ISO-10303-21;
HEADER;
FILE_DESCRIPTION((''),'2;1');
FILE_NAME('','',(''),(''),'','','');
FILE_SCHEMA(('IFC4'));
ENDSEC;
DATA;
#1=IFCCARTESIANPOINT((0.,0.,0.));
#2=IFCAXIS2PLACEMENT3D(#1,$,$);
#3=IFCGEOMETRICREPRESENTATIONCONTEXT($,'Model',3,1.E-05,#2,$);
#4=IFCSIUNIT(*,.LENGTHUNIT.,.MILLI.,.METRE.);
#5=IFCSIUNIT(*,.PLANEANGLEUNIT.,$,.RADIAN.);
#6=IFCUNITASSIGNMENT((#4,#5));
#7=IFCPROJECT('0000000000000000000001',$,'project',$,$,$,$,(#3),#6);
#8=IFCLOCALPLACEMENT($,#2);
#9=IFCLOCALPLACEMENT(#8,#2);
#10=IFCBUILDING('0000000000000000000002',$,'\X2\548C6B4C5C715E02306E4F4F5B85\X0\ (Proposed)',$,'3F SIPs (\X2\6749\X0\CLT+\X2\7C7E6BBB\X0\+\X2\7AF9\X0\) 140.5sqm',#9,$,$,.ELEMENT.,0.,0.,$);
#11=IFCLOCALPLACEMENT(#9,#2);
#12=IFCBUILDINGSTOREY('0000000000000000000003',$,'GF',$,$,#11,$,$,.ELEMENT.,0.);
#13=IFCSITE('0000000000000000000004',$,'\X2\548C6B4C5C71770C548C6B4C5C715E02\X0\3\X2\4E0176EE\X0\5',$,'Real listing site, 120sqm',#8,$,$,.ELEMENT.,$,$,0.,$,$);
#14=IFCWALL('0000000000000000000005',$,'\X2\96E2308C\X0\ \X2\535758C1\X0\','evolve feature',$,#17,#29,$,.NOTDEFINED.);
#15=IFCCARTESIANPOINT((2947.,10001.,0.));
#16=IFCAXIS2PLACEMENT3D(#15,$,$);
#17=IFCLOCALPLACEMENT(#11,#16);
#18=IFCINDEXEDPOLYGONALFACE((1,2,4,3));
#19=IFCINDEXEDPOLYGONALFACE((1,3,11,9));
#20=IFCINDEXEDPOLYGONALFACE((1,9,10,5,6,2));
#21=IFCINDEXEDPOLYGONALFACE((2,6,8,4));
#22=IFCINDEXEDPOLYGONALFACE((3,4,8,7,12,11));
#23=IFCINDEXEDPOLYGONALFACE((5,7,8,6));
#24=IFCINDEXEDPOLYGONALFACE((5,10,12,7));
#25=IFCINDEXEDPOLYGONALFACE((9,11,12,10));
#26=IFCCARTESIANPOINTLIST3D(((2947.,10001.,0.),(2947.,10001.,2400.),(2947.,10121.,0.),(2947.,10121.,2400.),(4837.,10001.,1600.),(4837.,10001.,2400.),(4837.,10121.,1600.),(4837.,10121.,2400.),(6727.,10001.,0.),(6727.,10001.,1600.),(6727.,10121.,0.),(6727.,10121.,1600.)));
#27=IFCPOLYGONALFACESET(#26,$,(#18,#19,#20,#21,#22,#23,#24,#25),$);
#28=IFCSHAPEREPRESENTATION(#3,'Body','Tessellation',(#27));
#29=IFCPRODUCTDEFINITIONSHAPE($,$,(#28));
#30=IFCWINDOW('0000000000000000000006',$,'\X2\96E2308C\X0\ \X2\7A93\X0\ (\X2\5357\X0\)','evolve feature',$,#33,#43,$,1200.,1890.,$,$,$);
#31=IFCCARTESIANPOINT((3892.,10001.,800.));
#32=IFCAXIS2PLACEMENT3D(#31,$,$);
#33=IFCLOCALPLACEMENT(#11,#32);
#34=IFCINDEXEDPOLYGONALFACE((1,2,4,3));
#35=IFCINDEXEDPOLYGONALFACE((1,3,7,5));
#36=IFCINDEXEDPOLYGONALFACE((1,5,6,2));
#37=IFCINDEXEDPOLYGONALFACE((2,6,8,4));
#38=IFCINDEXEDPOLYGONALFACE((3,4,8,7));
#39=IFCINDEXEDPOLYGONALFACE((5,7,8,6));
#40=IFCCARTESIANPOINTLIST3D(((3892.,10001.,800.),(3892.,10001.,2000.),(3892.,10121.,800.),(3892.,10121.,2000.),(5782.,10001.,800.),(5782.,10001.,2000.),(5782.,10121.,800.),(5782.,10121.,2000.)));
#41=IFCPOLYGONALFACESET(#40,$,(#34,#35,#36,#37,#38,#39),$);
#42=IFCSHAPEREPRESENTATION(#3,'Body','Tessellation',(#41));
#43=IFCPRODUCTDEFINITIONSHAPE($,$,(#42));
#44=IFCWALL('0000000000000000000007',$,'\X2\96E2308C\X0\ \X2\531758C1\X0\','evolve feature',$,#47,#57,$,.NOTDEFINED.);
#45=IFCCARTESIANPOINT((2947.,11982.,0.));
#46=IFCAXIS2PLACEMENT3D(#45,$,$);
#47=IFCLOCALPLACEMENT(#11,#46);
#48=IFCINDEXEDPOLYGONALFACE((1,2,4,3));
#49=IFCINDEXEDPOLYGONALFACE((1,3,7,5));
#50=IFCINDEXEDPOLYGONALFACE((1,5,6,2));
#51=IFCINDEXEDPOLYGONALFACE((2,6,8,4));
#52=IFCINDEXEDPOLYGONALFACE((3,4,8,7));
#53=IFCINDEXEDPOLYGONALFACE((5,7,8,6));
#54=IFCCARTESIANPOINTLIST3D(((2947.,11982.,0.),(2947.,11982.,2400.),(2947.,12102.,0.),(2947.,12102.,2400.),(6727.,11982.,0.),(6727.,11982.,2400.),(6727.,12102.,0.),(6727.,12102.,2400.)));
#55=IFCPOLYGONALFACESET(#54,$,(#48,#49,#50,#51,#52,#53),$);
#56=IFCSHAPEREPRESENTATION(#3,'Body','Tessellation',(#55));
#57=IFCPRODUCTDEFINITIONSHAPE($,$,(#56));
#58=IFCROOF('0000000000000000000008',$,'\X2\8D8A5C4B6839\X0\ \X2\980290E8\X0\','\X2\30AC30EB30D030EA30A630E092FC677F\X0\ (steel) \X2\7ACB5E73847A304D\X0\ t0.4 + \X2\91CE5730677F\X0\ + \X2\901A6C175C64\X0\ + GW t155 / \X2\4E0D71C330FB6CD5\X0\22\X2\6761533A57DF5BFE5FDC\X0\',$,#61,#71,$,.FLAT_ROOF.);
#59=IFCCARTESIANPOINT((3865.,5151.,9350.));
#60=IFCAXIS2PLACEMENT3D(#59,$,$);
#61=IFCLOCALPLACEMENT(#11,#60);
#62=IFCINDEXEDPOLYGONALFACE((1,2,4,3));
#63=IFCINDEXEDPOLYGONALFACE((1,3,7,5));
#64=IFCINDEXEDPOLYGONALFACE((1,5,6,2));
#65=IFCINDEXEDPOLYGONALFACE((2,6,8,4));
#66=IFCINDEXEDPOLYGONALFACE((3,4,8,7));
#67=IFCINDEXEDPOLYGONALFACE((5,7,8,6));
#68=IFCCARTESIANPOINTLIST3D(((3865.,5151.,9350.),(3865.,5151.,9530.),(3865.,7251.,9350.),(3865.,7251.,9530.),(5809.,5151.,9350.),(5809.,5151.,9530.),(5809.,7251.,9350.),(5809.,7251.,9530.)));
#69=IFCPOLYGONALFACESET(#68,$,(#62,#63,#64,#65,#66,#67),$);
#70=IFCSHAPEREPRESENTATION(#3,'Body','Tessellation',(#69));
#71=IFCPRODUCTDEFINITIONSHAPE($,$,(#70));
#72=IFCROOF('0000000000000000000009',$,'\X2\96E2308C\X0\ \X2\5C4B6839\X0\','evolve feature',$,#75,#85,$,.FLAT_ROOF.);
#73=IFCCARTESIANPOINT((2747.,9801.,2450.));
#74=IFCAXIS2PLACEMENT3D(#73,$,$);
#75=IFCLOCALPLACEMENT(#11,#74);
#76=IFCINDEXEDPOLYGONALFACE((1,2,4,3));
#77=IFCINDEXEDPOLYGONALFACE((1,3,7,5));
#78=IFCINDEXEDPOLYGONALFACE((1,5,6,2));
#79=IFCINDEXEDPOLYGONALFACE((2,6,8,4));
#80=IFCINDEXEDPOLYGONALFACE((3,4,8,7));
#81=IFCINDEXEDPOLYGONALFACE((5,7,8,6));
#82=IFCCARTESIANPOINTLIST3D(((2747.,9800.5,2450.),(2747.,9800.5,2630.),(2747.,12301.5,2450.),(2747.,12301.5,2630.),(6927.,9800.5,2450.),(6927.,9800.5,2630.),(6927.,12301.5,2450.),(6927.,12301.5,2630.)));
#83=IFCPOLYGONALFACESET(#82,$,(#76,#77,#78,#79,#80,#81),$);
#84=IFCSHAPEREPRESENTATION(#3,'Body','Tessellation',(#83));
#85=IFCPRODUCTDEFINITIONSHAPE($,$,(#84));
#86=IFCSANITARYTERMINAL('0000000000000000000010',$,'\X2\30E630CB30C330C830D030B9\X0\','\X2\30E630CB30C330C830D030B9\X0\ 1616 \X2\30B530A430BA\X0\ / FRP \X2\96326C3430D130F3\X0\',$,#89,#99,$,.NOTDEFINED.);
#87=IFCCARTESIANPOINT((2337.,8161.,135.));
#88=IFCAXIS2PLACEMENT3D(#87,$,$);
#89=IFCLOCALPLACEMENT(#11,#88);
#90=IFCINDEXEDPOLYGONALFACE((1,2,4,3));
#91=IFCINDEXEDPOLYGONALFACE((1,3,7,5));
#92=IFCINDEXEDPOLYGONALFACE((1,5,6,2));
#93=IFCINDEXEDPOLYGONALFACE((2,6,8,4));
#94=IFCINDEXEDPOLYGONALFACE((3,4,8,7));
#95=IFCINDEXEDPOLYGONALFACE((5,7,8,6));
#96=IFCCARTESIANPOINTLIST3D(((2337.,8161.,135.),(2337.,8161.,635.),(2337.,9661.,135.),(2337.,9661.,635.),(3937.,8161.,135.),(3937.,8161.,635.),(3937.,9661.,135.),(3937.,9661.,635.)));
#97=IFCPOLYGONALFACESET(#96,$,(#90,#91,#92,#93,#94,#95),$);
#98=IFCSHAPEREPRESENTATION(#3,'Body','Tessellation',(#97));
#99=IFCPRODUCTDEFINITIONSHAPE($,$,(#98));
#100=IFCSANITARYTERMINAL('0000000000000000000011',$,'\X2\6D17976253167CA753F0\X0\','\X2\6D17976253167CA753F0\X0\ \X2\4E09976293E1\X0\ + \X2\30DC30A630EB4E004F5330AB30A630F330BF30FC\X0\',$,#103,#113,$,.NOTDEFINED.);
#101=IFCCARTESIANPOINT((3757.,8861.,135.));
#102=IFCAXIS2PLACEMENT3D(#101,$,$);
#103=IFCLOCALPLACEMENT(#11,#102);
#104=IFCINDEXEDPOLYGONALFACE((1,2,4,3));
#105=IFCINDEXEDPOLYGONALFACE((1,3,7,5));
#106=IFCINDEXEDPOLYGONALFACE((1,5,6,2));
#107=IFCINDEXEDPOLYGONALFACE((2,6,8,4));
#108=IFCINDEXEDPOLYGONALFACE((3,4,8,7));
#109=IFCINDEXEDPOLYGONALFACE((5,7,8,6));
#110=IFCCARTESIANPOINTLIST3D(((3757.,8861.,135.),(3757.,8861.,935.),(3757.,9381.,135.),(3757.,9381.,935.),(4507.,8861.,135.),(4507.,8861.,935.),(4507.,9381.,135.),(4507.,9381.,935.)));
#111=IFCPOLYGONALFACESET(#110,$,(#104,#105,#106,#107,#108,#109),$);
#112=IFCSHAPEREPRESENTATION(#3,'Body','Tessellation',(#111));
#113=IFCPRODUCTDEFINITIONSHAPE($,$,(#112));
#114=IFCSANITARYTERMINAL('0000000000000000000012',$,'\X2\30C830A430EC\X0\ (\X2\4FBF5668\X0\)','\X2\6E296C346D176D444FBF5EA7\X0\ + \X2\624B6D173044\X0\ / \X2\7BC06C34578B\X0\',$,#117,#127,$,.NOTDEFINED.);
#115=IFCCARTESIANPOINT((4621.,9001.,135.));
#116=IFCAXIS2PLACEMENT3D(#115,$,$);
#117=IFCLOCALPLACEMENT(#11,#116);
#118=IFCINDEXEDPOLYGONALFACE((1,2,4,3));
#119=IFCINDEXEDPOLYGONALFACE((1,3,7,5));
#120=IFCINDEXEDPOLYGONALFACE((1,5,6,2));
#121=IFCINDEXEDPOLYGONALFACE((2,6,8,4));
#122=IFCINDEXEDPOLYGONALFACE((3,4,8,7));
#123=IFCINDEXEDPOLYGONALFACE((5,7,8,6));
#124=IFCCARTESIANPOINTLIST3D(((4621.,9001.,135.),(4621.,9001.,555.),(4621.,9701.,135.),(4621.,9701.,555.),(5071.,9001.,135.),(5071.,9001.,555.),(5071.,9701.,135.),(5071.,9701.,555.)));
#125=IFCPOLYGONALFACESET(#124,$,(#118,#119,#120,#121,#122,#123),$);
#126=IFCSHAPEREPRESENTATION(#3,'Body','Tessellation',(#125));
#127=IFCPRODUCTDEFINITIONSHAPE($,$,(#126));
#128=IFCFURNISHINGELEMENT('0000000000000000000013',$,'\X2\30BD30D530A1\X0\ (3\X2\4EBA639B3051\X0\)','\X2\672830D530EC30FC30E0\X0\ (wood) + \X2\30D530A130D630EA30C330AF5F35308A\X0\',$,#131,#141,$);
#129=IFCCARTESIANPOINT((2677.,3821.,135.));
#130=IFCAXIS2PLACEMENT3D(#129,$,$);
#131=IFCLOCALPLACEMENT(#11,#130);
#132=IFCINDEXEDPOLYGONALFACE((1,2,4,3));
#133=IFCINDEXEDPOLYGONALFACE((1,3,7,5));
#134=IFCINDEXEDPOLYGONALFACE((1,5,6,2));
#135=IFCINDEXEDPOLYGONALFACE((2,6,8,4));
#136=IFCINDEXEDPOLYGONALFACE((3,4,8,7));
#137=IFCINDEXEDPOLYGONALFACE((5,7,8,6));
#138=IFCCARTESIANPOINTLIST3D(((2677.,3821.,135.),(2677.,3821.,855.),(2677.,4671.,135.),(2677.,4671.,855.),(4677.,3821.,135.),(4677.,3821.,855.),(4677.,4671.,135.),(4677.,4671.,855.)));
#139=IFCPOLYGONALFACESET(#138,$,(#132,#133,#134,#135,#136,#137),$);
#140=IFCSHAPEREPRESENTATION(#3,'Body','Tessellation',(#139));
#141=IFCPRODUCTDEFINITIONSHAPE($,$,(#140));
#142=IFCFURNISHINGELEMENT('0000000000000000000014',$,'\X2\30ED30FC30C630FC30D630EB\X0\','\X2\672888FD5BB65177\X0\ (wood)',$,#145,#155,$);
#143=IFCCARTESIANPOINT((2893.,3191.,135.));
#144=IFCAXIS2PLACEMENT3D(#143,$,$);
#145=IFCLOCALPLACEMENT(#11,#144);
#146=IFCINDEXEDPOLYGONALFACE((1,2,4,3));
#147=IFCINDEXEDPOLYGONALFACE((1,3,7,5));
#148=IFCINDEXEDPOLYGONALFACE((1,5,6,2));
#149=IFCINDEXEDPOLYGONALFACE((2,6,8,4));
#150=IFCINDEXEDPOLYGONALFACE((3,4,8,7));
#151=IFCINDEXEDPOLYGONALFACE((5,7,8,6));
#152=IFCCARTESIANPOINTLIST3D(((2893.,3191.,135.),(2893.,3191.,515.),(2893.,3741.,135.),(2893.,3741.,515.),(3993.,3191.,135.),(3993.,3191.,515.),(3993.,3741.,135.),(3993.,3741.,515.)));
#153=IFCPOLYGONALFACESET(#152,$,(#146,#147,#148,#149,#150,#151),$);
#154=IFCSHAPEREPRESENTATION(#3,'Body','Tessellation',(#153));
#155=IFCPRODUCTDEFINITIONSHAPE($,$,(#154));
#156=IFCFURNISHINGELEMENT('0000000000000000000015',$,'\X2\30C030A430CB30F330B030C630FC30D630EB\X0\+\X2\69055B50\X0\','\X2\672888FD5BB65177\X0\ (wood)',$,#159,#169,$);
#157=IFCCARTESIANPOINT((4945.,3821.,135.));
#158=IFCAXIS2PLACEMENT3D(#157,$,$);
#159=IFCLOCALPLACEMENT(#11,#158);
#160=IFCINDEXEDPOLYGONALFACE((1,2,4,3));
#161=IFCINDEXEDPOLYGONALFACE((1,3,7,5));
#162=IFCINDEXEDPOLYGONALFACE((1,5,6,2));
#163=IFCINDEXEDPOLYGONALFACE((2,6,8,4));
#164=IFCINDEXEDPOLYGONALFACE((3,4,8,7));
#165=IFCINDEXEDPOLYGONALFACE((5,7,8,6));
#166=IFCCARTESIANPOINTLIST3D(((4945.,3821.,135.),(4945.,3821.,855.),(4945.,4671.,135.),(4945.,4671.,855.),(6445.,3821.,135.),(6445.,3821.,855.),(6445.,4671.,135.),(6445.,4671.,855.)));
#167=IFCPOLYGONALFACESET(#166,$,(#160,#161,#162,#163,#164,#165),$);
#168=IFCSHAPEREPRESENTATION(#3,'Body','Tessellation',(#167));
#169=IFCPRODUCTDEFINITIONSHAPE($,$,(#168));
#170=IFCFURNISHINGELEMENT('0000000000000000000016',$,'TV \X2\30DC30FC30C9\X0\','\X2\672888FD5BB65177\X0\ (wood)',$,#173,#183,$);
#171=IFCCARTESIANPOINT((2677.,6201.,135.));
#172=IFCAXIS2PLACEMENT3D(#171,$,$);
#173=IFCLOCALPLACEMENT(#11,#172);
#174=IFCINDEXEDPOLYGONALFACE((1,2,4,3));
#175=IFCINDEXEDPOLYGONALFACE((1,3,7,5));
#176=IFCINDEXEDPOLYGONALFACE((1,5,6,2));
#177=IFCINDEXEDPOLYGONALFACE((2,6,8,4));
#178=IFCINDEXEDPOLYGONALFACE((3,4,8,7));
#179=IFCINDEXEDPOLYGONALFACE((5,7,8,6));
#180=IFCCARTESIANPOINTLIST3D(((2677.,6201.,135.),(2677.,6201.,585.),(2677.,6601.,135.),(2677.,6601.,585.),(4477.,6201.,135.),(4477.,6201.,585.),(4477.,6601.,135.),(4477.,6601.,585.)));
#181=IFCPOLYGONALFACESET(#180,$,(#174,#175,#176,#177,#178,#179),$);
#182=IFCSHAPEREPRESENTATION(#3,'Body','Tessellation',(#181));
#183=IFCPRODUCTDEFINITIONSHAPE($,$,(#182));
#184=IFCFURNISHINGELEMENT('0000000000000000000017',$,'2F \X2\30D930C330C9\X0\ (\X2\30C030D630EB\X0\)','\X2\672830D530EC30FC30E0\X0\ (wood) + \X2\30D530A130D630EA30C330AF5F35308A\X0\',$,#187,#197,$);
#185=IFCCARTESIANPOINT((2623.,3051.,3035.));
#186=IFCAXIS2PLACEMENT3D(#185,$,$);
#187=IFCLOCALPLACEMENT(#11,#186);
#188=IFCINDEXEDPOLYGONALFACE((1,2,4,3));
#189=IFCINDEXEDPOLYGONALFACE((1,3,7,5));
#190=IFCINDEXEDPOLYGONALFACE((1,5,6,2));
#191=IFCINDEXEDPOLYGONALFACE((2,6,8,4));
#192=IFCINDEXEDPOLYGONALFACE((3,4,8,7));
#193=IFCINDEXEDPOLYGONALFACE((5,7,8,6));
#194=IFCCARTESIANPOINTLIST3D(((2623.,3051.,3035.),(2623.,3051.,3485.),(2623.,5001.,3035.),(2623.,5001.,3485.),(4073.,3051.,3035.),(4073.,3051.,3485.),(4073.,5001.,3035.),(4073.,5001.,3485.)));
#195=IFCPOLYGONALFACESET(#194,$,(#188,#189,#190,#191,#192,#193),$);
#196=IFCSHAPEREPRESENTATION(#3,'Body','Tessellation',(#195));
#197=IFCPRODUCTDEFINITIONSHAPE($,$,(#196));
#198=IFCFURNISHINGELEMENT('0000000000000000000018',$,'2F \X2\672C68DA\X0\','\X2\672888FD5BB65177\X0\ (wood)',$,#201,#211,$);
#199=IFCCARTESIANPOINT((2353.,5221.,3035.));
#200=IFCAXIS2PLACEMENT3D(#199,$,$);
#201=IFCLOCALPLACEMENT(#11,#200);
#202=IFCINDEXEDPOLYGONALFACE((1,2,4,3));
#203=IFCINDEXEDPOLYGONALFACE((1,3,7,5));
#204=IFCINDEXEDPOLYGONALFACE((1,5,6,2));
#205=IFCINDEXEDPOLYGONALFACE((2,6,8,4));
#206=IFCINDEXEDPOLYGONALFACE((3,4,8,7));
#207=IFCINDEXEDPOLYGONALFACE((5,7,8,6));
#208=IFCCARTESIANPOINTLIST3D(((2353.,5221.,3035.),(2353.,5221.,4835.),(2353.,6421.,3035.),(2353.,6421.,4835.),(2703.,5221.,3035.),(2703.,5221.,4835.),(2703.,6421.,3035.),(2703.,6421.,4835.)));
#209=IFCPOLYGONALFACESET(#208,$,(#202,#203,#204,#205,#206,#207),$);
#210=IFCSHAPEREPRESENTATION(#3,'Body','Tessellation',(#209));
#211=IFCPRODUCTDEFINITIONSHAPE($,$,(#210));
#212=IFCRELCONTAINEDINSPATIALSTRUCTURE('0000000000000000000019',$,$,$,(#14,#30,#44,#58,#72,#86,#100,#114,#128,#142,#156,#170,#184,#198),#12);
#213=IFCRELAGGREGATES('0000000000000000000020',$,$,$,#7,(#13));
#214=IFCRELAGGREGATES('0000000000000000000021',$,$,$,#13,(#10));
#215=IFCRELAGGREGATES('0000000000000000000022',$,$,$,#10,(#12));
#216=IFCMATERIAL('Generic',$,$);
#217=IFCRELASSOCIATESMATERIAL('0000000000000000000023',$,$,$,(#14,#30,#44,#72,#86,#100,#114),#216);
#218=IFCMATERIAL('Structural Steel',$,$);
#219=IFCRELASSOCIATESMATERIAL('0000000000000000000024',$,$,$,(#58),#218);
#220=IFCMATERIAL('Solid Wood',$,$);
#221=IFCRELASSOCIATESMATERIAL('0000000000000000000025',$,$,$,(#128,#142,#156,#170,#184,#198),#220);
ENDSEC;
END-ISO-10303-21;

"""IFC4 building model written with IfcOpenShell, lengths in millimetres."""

from ifc_helpers import new_model, si_unit, frame, frame_2d, origin, place, context, project, spatial, rectangle, extrude, material, element, fill, save


model = new_model("IFC4")

# Units and contexts
model_context = context("Model", 3, precision=1e-05, world=origin())
ifc_project = project(units=[si_unit("LENGTHUNIT", "METRE", prefix="MILLI"), si_unit("PLANEANGLEUNIT", "RADIAN")], contexts=[model_context])

# Site, building, storey
site_placement = place(None, origin())
site = spatial("IfcSite", under=ifc_project, at=site_placement, Name="和歌山県和歌山市3丁目5", ObjectType="Real listing site, 120sqm", CompositionType="ELEMENT", RefElevation=0.0)
building_placement = place(site_placement, origin())
building = spatial("IfcBuilding", under=site, at=building_placement, Name="和歌山市の住宅 (Proposed)", ObjectType="3F SIPs (杉CLT+籾殻+竹) 140.5sqm", CompositionType="ELEMENT", ElevationOfRefHeight=0.0, ElevationOfTerrain=0.0)
storey_placement = place(building_placement, origin())
storey = spatial("IfcBuildingStorey", under=building, at=storey_placement, Name="GF", CompositionType="ELEMENT", Elevation=0.0)

# Shared definitions
ifc_material_1 = material(Name="Generic")

# Shared definitions
ifc_material_2 = material(Name="Solid Wood")

# Wall, opening, window
wall_1_placement = place(storey_placement, frame((2947.0, 10001.0, 0.0)))
wall_1 = element("IfcWall", 1, at=wall_1_placement, inside=storey, material=ifc_material_1, Name="離れ 南壁", Description="evolve feature", PredefinedType="NOTDEFINED", context=model_context, shape_type="SweptSolid", body=[
    extrude(rectangle(XDim=3780.0, YDim=120.0, at=frame_2d((1890.0, 60.0))), frame((2947.0, 10001.0, 0.0)), (0.0, 0.0, 1.0), 2400.0),
])
opening_1_placement = place(storey_placement, frame((3892.0, 10001.0, 800.0)))
opening_1 = element("IfcOpeningElement", 2, at=opening_1_placement, cuts=wall_1, PredefinedType="NOTDEFINED", context=model_context, shape_type="SweptSolid", body=[
    extrude(rectangle(XDim=1890.0, YDim=120.0, at=frame_2d((945.0, 60.0))), frame((3892.0, 10001.0, 800.0)), (0.0, 0.0, 1.0), 1200.0),
])
window_1_placement = place(storey_placement, frame((3892.0, 10001.0, 800.0)))
window_1 = element("IfcWindow", 3, at=window_1_placement, inside=storey, material=ifc_material_1, Name="離れ 窓 (南)", Description="evolve feature", OverallHeight=1200.0, OverallWidth=1890.0, context=model_context, shape_type="SweptSolid", body=[
    extrude(rectangle(XDim=1890.0, YDim=120.0, at=frame_2d((945.0, 60.0))), frame((3892.0, 10001.0, 800.0)), (0.0, 0.0, 1.0), 1200.0),
])
fill(opening_1, window_1)

# Wall
wall_2_placement = place(storey_placement, frame((2947.0, 11982.0, 0.0)))
element("IfcWall", 4, at=wall_2_placement, inside=storey, material=ifc_material_1, Name="離れ 北壁", Description="evolve feature", PredefinedType="NOTDEFINED", context=model_context, shape_type="SweptSolid", body=[
    extrude(rectangle(XDim=3780.0, YDim=120.0, at=frame_2d((1890.0, 60.0))), frame((2947.0, 11982.0, 0.0)), (0.0, 0.0, 1.0), 2400.0),
])

# Roofs
ifc_material_3 = material(Name="Structural Steel")
roof_1_placement = place(storey_placement, frame((3865.0, 5151.0, 9350.0)))
element("IfcRoof", 5, at=roof_1_placement, inside=storey, material=ifc_material_3, Name="越屋根 頂部", Description="ガルバリウム鋼板 (steel) 立平葺き t0.4 + 野地板 + 通気層 + GW t155 / 不燃・法22条区域対応", PredefinedType="FLAT_ROOF", context=model_context, shape_type="SweptSolid", body=[
    extrude(rectangle(XDim=1944.0, YDim=2100.0, at=frame_2d((972.0, 1050.0))), frame((3865.0, 5151.0, 9350.0)), (0.0, 0.0, 1.0), 180.0),
])
roof_2_placement = place(storey_placement, frame((2747.0, 9801.0, 2450.0)))
element("IfcRoof", 6, at=roof_2_placement, inside=storey, material=ifc_material_1, Name="離れ 屋根", Description="evolve feature", PredefinedType="FLAT_ROOF", context=model_context, shape_type="SweptSolid", body=[
    extrude(rectangle(XDim=4180.0, YDim=2501.0, at=frame_2d((2090.0, 1250.0))), frame((2747.0, 9801.0, 2450.0)), (0.0, 0.0, 1.0), 180.0),
])

# Sanitary terminals
sanitary_terminal_1_placement = place(storey_placement, frame((2337.0, 8161.0, 135.0)))
element("IfcSanitaryTerminal", 7, at=sanitary_terminal_1_placement, inside=storey, material=ifc_material_1, Name="ユニットバス", Description="ユニットバス 1616 サイズ / FRP 防水パン", PredefinedType="NOTDEFINED", context=model_context, shape_type="SweptSolid", body=[
    extrude(rectangle(XDim=1600.0, YDim=1500.0, at=frame_2d((800.0, 750.0))), frame((2337.0, 8161.0, 135.0)), (0.0, 0.0, 1.0), 500.0),
])
sanitary_terminal_2_placement = place(storey_placement, frame((3757.0, 8861.0, 135.0)))
element("IfcSanitaryTerminal", 8, at=sanitary_terminal_2_placement, inside=storey, material=ifc_material_1, Name="洗面化粧台", Description="洗面化粧台 三面鏡 + ボウル一体カウンター", PredefinedType="NOTDEFINED", context=model_context, shape_type="SweptSolid", body=[
    extrude(rectangle(XDim=750.0, YDim=520.0, at=frame_2d((375.0, 260.0))), frame((3757.0, 8861.0, 135.0)), (0.0, 0.0, 1.0), 800.0),
])
sanitary_terminal_3_placement = place(storey_placement, frame((4621.0, 9001.0, 135.0)))
element("IfcSanitaryTerminal", 9, at=sanitary_terminal_3_placement, inside=storey, material=ifc_material_1, Name="トイレ (便器)", Description="温水洗浄便座 + 手洗い / 節水型", PredefinedType="NOTDEFINED", context=model_context, shape_type="SweptSolid", body=[
    extrude(rectangle(XDim=450.0, YDim=700.0, at=frame_2d((225.0, 350.0))), frame((4621.0, 9001.0, 135.0)), (0.0, 0.0, 1.0), 420.0),
])

# Furnishing elements
furnishing_1_placement = place(storey_placement, frame((2677.0, 3821.0, 135.0)))
element("IfcFurnishingElement", 10, at=furnishing_1_placement, inside=storey, material=ifc_material_2, Name="ソファ (3人掛け)", Description="木フレーム (wood) + ファブリック張り", context=model_context, shape_type="SweptSolid", body=[
    extrude(rectangle(XDim=2000.0, YDim=850.0, at=frame_2d((1000.0, 425.0))), frame((2677.0, 3821.0, 135.0)), (0.0, 0.0, 1.0), 720.0),
])
furnishing_2_placement = place(storey_placement, frame((2893.0, 3191.0, 135.0)))
element("IfcFurnishingElement", 11, at=furnishing_2_placement, inside=storey, material=ifc_material_2, Name="ローテーブル", Description="木製家具 (wood)", context=model_context, shape_type="SweptSolid", body=[
    extrude(rectangle(XDim=1100.0, YDim=550.0, at=frame_2d((550.0, 275.0))), frame((2893.0, 3191.0, 135.0)), (0.0, 0.0, 1.0), 380.0),
])
furnishing_3_placement = place(storey_placement, frame((4945.0, 3821.0, 135.0)))
element("IfcFurnishingElement", 12, at=furnishing_3_placement, inside=storey, material=ifc_material_2, Name="ダイニングテーブル+椅子", Description="木製家具 (wood)", context=model_context, shape_type="SweptSolid", body=[
    extrude(rectangle(XDim=1500.0, YDim=850.0, at=frame_2d((750.0, 425.0))), frame((4945.0, 3821.0, 135.0)), (0.0, 0.0, 1.0), 720.0),
])
furnishing_4_placement = place(storey_placement, frame((2677.0, 6201.0, 135.0)))
element("IfcFurnishingElement", 13, at=furnishing_4_placement, inside=storey, material=ifc_material_2, Name="TV ボード", Description="木製家具 (wood)", context=model_context, shape_type="SweptSolid", body=[
    extrude(rectangle(XDim=1800.0, YDim=400.0, at=frame_2d((900.0, 200.0))), frame((2677.0, 6201.0, 135.0)), (0.0, 0.0, 1.0), 450.0),
])
furnishing_5_placement = place(storey_placement, frame((2623.0, 3051.0, 3035.0)))
element("IfcFurnishingElement", 14, at=furnishing_5_placement, inside=storey, material=ifc_material_2, Name="2F ベッド (ダブル)", Description="木フレーム (wood) + ファブリック張り", context=model_context, shape_type="SweptSolid", body=[
    extrude(rectangle(XDim=1450.0, YDim=1950.0, at=frame_2d((725.0, 975.0))), frame((2623.0, 3051.0, 3035.0)), (0.0, 0.0, 1.0), 450.0),
])
furnishing_6_placement = place(storey_placement, frame((2353.0, 5221.0, 3035.0)))
element("IfcFurnishingElement", 15, at=furnishing_6_placement, inside=storey, material=ifc_material_2, Name="2F 本棚", Description="木製家具 (wood)", context=model_context, shape_type="SweptSolid", body=[
    extrude(rectangle(XDim=350.0, YDim=1200.0, at=frame_2d((175.0, 600.0))), frame((2353.0, 5221.0, 3035.0)), (0.0, 0.0, 1.0), 1800.0),
])

save(model, "model.ifc")
